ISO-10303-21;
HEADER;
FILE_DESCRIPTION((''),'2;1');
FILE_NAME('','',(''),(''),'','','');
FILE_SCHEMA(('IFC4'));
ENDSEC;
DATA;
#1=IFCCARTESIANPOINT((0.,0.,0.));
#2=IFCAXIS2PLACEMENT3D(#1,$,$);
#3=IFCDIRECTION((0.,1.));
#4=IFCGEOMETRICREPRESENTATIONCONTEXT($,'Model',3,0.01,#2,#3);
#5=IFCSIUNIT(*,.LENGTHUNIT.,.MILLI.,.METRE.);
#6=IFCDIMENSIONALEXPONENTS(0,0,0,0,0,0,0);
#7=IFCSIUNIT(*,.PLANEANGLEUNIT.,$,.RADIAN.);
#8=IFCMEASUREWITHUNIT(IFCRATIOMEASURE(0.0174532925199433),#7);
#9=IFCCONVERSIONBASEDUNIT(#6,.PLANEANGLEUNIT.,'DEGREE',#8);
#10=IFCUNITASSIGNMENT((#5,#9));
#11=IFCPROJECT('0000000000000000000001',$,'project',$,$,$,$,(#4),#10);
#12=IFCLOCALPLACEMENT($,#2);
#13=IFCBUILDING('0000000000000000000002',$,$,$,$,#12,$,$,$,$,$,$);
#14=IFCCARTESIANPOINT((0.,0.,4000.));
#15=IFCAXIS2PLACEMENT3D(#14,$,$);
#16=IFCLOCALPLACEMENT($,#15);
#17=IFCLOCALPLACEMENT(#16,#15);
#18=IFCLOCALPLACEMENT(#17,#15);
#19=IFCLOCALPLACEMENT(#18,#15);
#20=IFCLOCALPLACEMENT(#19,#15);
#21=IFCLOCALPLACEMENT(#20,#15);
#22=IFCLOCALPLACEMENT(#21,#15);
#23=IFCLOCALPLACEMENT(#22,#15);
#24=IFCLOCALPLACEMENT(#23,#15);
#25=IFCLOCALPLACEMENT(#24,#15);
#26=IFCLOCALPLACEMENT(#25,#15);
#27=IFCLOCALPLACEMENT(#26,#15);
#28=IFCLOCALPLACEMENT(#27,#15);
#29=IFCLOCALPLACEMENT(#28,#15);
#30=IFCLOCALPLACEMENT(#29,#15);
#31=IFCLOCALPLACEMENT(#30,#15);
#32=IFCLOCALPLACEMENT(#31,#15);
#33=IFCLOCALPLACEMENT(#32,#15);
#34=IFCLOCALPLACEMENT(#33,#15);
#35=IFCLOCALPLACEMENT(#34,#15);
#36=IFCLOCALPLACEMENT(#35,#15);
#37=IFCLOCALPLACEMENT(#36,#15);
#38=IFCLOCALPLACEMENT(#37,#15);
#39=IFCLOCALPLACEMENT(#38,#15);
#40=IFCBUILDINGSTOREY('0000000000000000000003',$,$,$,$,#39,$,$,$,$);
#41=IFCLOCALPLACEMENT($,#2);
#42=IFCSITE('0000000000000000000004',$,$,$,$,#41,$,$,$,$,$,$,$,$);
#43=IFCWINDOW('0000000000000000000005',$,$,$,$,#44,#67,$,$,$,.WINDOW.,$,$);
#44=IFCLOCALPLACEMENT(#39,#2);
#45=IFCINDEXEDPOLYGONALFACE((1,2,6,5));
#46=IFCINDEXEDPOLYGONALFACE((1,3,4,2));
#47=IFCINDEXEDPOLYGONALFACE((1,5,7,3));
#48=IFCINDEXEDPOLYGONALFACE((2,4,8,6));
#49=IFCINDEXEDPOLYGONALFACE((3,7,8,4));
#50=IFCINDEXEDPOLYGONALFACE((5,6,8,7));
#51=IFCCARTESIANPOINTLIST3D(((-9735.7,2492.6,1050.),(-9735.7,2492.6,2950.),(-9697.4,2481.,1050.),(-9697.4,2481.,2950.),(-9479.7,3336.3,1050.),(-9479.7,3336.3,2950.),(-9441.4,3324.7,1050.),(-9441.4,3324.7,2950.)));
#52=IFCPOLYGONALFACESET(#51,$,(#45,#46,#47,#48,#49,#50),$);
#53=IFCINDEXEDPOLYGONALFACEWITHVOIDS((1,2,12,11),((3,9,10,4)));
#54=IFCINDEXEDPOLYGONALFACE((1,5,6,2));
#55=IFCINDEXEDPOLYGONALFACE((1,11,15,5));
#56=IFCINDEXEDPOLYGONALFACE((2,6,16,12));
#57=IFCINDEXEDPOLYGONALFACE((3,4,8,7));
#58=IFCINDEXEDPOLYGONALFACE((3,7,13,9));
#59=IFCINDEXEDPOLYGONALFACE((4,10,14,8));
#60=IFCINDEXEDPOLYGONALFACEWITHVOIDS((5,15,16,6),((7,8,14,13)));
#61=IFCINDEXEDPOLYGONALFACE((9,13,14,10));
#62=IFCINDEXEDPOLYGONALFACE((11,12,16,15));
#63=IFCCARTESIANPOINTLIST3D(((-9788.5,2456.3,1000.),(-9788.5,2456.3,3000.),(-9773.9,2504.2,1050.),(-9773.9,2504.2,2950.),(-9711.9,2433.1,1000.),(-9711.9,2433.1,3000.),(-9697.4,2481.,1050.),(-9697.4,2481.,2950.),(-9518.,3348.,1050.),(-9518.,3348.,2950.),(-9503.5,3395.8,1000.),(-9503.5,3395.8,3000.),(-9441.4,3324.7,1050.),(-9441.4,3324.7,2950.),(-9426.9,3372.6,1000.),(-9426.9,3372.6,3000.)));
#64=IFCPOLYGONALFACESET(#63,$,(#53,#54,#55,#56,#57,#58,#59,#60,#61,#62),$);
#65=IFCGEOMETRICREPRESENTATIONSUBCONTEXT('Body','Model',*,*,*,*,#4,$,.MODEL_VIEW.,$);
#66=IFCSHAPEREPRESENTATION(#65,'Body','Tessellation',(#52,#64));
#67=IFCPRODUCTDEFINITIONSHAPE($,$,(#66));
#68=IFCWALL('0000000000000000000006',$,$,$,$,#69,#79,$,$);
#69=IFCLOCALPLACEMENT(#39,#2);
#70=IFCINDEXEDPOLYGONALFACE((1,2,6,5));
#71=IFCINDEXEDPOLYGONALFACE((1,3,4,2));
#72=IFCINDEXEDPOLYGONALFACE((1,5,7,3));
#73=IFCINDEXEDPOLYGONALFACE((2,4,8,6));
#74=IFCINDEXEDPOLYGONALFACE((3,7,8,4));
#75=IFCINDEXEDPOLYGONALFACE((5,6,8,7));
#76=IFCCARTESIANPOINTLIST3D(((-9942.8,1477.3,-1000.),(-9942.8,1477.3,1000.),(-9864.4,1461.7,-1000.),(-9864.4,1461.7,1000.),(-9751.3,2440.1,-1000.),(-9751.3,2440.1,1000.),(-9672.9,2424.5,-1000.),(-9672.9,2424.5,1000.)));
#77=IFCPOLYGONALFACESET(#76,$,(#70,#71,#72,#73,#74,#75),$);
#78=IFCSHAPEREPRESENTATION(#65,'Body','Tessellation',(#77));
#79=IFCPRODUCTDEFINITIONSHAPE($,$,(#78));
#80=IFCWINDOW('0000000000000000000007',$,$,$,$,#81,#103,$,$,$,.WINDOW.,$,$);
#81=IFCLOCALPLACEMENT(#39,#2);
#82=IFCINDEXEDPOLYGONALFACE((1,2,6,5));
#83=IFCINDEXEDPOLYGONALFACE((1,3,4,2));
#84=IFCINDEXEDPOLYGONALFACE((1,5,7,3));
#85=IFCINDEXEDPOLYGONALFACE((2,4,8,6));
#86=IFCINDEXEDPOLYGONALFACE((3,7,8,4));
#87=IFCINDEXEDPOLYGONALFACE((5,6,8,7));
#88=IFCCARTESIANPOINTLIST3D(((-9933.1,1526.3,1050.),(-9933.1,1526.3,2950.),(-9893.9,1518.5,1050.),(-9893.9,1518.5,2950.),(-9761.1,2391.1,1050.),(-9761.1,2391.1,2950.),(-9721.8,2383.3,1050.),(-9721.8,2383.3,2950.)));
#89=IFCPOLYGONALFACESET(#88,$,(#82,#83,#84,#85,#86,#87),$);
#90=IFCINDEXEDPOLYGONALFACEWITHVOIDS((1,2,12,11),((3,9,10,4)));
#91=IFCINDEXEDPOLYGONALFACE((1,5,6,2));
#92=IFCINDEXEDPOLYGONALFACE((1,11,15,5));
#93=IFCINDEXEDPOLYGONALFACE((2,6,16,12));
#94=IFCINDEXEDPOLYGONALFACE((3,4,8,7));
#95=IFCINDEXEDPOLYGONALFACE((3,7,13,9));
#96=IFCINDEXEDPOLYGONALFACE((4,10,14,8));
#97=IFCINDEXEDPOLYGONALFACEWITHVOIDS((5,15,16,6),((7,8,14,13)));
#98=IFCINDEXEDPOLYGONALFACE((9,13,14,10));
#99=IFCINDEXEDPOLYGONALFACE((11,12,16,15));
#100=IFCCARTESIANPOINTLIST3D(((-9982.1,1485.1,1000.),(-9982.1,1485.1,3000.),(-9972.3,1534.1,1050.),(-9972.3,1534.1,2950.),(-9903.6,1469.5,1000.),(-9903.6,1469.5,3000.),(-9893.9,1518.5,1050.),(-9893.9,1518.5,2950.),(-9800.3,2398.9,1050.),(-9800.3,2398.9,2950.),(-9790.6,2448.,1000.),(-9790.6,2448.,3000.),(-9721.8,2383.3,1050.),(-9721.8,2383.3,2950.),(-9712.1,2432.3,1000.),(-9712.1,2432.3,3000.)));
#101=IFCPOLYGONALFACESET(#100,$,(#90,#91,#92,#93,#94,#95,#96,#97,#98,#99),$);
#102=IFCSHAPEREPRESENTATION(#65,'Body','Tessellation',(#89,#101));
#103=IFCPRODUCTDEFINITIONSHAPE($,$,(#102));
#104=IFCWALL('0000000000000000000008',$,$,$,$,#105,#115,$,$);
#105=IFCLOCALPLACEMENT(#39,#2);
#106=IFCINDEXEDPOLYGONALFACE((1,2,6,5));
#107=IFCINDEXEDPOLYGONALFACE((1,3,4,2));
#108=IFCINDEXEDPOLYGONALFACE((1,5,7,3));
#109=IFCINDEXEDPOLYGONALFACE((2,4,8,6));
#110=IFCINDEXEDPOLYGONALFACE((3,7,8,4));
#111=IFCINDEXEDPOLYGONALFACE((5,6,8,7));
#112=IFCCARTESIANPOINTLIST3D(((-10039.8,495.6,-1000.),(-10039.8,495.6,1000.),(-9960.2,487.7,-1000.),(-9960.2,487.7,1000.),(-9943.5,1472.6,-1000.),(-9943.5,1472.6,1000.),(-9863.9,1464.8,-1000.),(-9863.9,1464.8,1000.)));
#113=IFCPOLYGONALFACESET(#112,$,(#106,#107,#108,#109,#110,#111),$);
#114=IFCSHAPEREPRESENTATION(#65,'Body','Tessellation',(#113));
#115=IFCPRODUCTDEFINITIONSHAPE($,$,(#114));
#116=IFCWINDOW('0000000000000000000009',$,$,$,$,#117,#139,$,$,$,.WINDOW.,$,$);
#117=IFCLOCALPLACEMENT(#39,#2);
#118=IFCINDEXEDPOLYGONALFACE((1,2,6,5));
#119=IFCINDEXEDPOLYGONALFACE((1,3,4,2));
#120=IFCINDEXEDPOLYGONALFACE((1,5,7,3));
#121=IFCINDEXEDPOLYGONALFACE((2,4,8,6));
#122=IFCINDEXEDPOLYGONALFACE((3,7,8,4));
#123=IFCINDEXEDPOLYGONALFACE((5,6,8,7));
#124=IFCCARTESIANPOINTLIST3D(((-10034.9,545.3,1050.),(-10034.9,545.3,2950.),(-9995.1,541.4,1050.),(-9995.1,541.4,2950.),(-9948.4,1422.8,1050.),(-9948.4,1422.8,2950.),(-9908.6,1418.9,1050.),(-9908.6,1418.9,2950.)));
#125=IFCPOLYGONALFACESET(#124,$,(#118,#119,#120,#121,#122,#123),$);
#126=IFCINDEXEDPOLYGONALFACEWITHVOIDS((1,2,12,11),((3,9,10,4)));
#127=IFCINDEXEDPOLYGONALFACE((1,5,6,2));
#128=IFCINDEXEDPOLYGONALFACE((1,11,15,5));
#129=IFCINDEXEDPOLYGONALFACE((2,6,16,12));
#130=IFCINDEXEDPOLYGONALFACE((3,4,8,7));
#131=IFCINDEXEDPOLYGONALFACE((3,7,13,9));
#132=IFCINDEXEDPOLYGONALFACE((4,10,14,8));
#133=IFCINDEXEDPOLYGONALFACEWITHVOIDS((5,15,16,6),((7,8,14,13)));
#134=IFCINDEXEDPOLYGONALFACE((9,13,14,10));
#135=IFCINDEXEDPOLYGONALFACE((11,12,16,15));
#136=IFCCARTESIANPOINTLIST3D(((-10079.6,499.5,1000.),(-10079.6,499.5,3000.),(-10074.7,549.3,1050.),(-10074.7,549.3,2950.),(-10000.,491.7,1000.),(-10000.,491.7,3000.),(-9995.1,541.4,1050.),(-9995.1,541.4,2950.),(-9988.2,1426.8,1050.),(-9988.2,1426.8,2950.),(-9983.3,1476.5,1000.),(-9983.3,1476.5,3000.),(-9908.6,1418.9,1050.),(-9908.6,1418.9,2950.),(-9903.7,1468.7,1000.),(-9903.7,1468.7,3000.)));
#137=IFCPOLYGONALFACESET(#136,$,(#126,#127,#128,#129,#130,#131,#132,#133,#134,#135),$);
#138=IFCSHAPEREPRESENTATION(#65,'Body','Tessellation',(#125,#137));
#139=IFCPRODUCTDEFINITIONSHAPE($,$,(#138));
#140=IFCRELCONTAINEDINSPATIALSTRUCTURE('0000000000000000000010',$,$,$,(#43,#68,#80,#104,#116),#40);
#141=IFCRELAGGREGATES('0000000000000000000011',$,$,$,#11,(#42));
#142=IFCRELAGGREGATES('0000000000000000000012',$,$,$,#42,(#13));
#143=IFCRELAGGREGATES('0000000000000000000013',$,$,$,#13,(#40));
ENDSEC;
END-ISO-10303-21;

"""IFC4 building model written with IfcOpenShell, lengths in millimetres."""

from ifc_helpers import new_model, entity, si_unit, converted_unit, direction, frame, origin, origin_2d, place, context, subcontext, project, spatial, rectangle, extrude, element, save


model = new_model("IFC4")

# Units and contexts
model_context = context("Model", 3, precision=0.01, world=origin(), true_north=direction((0.0, 1.0)))
body_context = subcontext(model_context, "Body", "Model", "MODEL_VIEW")
ifc_project = project(units=[si_unit("LENGTHUNIT", "METRE", prefix="MILLI"), converted_unit("PLANEANGLEUNIT", "DEGREE", entity("IfcRatioMeasure", 0.0174532925199433), si_unit("PLANEANGLEUNIT", "RADIAN"), dimensions=[0, 0, 0, 0, 0, 0, 0])], contexts=[model_context])

# Site, building, storey
site_placement = place(None, origin())
site = spatial("IfcSite", under=ifc_project, at=site_placement)
building_placement = place(None, origin())
building = spatial("IfcBuilding", under=site, at=building_placement)
placement_1 = place(None, frame((0.0, 0.0, 4000.0)))
placement_2 = place(placement_1, frame((0.0, 0.0, 4000.0)))
placement_3 = place(placement_2, frame((0.0, 0.0, 4000.0)))
placement_4 = place(placement_3, frame((0.0, 0.0, 4000.0)))
placement_5 = place(placement_4, frame((0.0, 0.0, 4000.0)))
placement_6 = place(placement_5, frame((0.0, 0.0, 4000.0)))
placement_7 = place(placement_6, frame((0.0, 0.0, 4000.0)))
placement_8 = place(placement_7, frame((0.0, 0.0, 4000.0)))
placement_9 = place(placement_8, frame((0.0, 0.0, 4000.0)))
placement_10 = place(placement_9, frame((0.0, 0.0, 4000.0)))
placement_11 = place(placement_10, frame((0.0, 0.0, 4000.0)))
placement_12 = place(placement_11, frame((0.0, 0.0, 4000.0)))
placement_13 = place(placement_12, frame((0.0, 0.0, 4000.0)))
placement_14 = place(placement_13, frame((0.0, 0.0, 4000.0)))
placement_15 = place(placement_14, frame((0.0, 0.0, 4000.0)))
placement_16 = place(placement_15, frame((0.0, 0.0, 4000.0)))
placement_17 = place(placement_16, frame((0.0, 0.0, 4000.0)))
placement_18 = place(placement_17, frame((0.0, 0.0, 4000.0)))
placement_19 = place(placement_18, frame((0.0, 0.0, 4000.0)))
placement_20 = place(placement_19, frame((0.0, 0.0, 4000.0)))
placement_21 = place(placement_20, frame((0.0, 0.0, 4000.0)))
placement_22 = place(placement_21, frame((0.0, 0.0, 4000.0)))
placement_23 = place(placement_22, frame((0.0, 0.0, 4000.0)))
storey_placement = place(placement_23, frame((0.0, 0.0, 4000.0)))
storey = spatial("IfcBuildingStorey", under=building, at=storey_placement)

# Shared definitions
cartesian_point_1 = entity("IfcCartesianPoint", [-440.9, -950.0])
shared_polyline = entity("IfcPolyline", [cartesian_point_1, entity("IfcCartesianPoint", [-440.9, 950.0]), entity("IfcCartesianPoint", [-440.9, 950.0]), entity("IfcCartesianPoint", [440.9, 950.0]), entity("IfcCartesianPoint", [440.9, 950.0]), entity("IfcCartesianPoint", [440.9, -950.0]), entity("IfcCartesianPoint", [440.9, -950.0]), entity("IfcCartesianPoint", [-440.9, -950.0]), cartesian_point_1])

# Window
window_1_placement = place(storey_placement, frame((-9569.4, 2902.8, 2000.0), z_axis=(0.0, 0.0, 1.0), x_axis=(-2902.847084, -9569.403263, 0.0)))
cartesian_point_2 = entity("IfcCartesianPoint", [-490.9, -1000.0])
element("IfcWindow", 1, at=window_1_placement, inside=storey, PredefinedType="WINDOW", context=body_context, shape_type="SweptSolid", body=[
    entity("IfcExtrudedAreaSolid", entity("IfcArbitraryClosedProfileDef", "AREA", None, shared_polyline), entity("IfcAxis2Placement3D", entity("IfcCartesianPoint", [0.0, 0.0, 0.0]), entity("IfcDirection", [0.0, -1.0, 0.0]), entity("IfcDirection", [1.0, 0.0, 0.0])), entity("IfcDirection", [0.0, 0.0, 1.0]), 40.0),
    entity("IfcExtrudedAreaSolid", entity("IfcArbitraryProfileDefWithVoids", "AREA", None, entity("IfcPolyline", [cartesian_point_2, entity("IfcCartesianPoint", [-490.9, 1000.0]), entity("IfcCartesianPoint", [-490.9, 1000.0]), entity("IfcCartesianPoint", [490.9, 1000.0]), entity("IfcCartesianPoint", [490.9, 1000.0]), entity("IfcCartesianPoint", [490.9, -1000.0]), entity("IfcCartesianPoint", [490.9, -1000.0]), entity("IfcCartesianPoint", [-490.9, -1000.0]), cartesian_point_2]), [shared_polyline]), entity("IfcAxis2Placement3D", entity("IfcCartesianPoint", [0.0, 0.0, 0.0]), entity("IfcDirection", [0.0, -1.0, 0.0]), entity("IfcDirection", [1.0, 0.0, 0.0])), entity("IfcDirection", [0.0, 0.0, 1.0]), 80.0),
])

# Wall
wall_1_placement = place(storey_placement, frame((-9807.9, 1950.9, -1000.0), z_axis=(0.0, 0.0, 1.0), x_axis=(-1950.903147, -9807.852819, 0.0)))
element("IfcWall", 2, at=wall_1_placement, inside=storey, context=body_context, shape_type="SweptSolid", body=[
    extrude(rectangle(XDim=981.7, YDim=80.0, at=origin_2d()), origin(), (0.0, 0.0, 1.0), 2000.0),
])

# Window
window_2_placement = place(storey_placement, frame((-9807.9, 1950.9, 2000.0), z_axis=(0.0, 0.0, 1.0), x_axis=(-1950.903147, -9807.852819, 0.0)))
cartesian_point_3 = entity("IfcCartesianPoint", [-490.9, -1000.0])
element("IfcWindow", 3, at=window_2_placement, inside=storey, PredefinedType="WINDOW", context=body_context, shape_type="SweptSolid", body=[
    entity("IfcExtrudedAreaSolid", entity("IfcArbitraryClosedProfileDef", "AREA", None, shared_polyline), entity("IfcAxis2Placement3D", entity("IfcCartesianPoint", [0.0, 0.0, 0.0]), entity("IfcDirection", [0.0, -1.0, 0.0]), entity("IfcDirection", [1.0, 0.0, 0.0])), entity("IfcDirection", [0.0, 0.0, 1.0]), 40.0),
    entity("IfcExtrudedAreaSolid", entity("IfcArbitraryProfileDefWithVoids", "AREA", None, entity("IfcPolyline", [cartesian_point_3, entity("IfcCartesianPoint", [-490.9, 1000.0]), entity("IfcCartesianPoint", [-490.9, 1000.0]), entity("IfcCartesianPoint", [490.9, 1000.0]), entity("IfcCartesianPoint", [490.9, 1000.0]), entity("IfcCartesianPoint", [490.9, -1000.0]), entity("IfcCartesianPoint", [490.9, -1000.0]), entity("IfcCartesianPoint", [-490.9, -1000.0]), cartesian_point_3]), [shared_polyline]), entity("IfcAxis2Placement3D", entity("IfcCartesianPoint", [0.0, 0.0, 0.0]), entity("IfcDirection", [0.0, -1.0, 0.0]), entity("IfcDirection", [1.0, 0.0, 0.0])), entity("IfcDirection", [0.0, 0.0, 1.0]), 80.0),
])

# Wall
wall_2_placement = place(storey_placement, frame((-9951.8, 980.2, -1000.0), z_axis=(0.0, 0.0, 1.0), x_axis=(-980.170931, -9951.847313, 0.0)))
element("IfcWall", 4, at=wall_2_placement, inside=storey, context=body_context, shape_type="SweptSolid", body=[
    extrude(rectangle(XDim=981.7, YDim=80.0, at=origin_2d()), origin(), (0.0, 0.0, 1.0), 2000.0),
])

# Window
window_3_placement = place(storey_placement, frame((-9951.8, 980.2, 2000.0), z_axis=(0.0, 0.0, 1.0), x_axis=(-980.170931, -9951.847313, 0.0)))
cartesian_point_4 = entity("IfcCartesianPoint", [-490.9, -1000.0])
element("IfcWindow", 5, at=window_3_placement, inside=storey, PredefinedType="WINDOW", context=body_context, shape_type="SweptSolid", body=[
    entity("IfcExtrudedAreaSolid", entity("IfcArbitraryClosedProfileDef", "AREA", None, shared_polyline), entity("IfcAxis2Placement3D", entity("IfcCartesianPoint", [0.0, 0.0, 0.0]), entity("IfcDirection", [0.0, -1.0, 0.0]), entity("IfcDirection", [1.0, 0.0, 0.0])), entity("IfcDirection", [0.0, 0.0, 1.0]), 40.0),
    entity("IfcExtrudedAreaSolid", entity("IfcArbitraryProfileDefWithVoids", "AREA", None, entity("IfcPolyline", [cartesian_point_4, entity("IfcCartesianPoint", [-490.9, 1000.0]), entity("IfcCartesianPoint", [-490.9, 1000.0]), entity("IfcCartesianPoint", [490.9, 1000.0]), entity("IfcCartesianPoint", [490.9, 1000.0]), entity("IfcCartesianPoint", [490.9, -1000.0]), entity("IfcCartesianPoint", [490.9, -1000.0]), entity("IfcCartesianPoint", [-490.9, -1000.0]), cartesian_point_4]), [shared_polyline]), entity("IfcAxis2Placement3D", entity("IfcCartesianPoint", [0.0, 0.0, 0.0]), entity("IfcDirection", [0.0, -1.0, 0.0]), entity("IfcDirection", [1.0, 0.0, 0.0])), entity("IfcDirection", [0.0, 0.0, 1.0]), 80.0),
])

save(model, "model.ifc")
